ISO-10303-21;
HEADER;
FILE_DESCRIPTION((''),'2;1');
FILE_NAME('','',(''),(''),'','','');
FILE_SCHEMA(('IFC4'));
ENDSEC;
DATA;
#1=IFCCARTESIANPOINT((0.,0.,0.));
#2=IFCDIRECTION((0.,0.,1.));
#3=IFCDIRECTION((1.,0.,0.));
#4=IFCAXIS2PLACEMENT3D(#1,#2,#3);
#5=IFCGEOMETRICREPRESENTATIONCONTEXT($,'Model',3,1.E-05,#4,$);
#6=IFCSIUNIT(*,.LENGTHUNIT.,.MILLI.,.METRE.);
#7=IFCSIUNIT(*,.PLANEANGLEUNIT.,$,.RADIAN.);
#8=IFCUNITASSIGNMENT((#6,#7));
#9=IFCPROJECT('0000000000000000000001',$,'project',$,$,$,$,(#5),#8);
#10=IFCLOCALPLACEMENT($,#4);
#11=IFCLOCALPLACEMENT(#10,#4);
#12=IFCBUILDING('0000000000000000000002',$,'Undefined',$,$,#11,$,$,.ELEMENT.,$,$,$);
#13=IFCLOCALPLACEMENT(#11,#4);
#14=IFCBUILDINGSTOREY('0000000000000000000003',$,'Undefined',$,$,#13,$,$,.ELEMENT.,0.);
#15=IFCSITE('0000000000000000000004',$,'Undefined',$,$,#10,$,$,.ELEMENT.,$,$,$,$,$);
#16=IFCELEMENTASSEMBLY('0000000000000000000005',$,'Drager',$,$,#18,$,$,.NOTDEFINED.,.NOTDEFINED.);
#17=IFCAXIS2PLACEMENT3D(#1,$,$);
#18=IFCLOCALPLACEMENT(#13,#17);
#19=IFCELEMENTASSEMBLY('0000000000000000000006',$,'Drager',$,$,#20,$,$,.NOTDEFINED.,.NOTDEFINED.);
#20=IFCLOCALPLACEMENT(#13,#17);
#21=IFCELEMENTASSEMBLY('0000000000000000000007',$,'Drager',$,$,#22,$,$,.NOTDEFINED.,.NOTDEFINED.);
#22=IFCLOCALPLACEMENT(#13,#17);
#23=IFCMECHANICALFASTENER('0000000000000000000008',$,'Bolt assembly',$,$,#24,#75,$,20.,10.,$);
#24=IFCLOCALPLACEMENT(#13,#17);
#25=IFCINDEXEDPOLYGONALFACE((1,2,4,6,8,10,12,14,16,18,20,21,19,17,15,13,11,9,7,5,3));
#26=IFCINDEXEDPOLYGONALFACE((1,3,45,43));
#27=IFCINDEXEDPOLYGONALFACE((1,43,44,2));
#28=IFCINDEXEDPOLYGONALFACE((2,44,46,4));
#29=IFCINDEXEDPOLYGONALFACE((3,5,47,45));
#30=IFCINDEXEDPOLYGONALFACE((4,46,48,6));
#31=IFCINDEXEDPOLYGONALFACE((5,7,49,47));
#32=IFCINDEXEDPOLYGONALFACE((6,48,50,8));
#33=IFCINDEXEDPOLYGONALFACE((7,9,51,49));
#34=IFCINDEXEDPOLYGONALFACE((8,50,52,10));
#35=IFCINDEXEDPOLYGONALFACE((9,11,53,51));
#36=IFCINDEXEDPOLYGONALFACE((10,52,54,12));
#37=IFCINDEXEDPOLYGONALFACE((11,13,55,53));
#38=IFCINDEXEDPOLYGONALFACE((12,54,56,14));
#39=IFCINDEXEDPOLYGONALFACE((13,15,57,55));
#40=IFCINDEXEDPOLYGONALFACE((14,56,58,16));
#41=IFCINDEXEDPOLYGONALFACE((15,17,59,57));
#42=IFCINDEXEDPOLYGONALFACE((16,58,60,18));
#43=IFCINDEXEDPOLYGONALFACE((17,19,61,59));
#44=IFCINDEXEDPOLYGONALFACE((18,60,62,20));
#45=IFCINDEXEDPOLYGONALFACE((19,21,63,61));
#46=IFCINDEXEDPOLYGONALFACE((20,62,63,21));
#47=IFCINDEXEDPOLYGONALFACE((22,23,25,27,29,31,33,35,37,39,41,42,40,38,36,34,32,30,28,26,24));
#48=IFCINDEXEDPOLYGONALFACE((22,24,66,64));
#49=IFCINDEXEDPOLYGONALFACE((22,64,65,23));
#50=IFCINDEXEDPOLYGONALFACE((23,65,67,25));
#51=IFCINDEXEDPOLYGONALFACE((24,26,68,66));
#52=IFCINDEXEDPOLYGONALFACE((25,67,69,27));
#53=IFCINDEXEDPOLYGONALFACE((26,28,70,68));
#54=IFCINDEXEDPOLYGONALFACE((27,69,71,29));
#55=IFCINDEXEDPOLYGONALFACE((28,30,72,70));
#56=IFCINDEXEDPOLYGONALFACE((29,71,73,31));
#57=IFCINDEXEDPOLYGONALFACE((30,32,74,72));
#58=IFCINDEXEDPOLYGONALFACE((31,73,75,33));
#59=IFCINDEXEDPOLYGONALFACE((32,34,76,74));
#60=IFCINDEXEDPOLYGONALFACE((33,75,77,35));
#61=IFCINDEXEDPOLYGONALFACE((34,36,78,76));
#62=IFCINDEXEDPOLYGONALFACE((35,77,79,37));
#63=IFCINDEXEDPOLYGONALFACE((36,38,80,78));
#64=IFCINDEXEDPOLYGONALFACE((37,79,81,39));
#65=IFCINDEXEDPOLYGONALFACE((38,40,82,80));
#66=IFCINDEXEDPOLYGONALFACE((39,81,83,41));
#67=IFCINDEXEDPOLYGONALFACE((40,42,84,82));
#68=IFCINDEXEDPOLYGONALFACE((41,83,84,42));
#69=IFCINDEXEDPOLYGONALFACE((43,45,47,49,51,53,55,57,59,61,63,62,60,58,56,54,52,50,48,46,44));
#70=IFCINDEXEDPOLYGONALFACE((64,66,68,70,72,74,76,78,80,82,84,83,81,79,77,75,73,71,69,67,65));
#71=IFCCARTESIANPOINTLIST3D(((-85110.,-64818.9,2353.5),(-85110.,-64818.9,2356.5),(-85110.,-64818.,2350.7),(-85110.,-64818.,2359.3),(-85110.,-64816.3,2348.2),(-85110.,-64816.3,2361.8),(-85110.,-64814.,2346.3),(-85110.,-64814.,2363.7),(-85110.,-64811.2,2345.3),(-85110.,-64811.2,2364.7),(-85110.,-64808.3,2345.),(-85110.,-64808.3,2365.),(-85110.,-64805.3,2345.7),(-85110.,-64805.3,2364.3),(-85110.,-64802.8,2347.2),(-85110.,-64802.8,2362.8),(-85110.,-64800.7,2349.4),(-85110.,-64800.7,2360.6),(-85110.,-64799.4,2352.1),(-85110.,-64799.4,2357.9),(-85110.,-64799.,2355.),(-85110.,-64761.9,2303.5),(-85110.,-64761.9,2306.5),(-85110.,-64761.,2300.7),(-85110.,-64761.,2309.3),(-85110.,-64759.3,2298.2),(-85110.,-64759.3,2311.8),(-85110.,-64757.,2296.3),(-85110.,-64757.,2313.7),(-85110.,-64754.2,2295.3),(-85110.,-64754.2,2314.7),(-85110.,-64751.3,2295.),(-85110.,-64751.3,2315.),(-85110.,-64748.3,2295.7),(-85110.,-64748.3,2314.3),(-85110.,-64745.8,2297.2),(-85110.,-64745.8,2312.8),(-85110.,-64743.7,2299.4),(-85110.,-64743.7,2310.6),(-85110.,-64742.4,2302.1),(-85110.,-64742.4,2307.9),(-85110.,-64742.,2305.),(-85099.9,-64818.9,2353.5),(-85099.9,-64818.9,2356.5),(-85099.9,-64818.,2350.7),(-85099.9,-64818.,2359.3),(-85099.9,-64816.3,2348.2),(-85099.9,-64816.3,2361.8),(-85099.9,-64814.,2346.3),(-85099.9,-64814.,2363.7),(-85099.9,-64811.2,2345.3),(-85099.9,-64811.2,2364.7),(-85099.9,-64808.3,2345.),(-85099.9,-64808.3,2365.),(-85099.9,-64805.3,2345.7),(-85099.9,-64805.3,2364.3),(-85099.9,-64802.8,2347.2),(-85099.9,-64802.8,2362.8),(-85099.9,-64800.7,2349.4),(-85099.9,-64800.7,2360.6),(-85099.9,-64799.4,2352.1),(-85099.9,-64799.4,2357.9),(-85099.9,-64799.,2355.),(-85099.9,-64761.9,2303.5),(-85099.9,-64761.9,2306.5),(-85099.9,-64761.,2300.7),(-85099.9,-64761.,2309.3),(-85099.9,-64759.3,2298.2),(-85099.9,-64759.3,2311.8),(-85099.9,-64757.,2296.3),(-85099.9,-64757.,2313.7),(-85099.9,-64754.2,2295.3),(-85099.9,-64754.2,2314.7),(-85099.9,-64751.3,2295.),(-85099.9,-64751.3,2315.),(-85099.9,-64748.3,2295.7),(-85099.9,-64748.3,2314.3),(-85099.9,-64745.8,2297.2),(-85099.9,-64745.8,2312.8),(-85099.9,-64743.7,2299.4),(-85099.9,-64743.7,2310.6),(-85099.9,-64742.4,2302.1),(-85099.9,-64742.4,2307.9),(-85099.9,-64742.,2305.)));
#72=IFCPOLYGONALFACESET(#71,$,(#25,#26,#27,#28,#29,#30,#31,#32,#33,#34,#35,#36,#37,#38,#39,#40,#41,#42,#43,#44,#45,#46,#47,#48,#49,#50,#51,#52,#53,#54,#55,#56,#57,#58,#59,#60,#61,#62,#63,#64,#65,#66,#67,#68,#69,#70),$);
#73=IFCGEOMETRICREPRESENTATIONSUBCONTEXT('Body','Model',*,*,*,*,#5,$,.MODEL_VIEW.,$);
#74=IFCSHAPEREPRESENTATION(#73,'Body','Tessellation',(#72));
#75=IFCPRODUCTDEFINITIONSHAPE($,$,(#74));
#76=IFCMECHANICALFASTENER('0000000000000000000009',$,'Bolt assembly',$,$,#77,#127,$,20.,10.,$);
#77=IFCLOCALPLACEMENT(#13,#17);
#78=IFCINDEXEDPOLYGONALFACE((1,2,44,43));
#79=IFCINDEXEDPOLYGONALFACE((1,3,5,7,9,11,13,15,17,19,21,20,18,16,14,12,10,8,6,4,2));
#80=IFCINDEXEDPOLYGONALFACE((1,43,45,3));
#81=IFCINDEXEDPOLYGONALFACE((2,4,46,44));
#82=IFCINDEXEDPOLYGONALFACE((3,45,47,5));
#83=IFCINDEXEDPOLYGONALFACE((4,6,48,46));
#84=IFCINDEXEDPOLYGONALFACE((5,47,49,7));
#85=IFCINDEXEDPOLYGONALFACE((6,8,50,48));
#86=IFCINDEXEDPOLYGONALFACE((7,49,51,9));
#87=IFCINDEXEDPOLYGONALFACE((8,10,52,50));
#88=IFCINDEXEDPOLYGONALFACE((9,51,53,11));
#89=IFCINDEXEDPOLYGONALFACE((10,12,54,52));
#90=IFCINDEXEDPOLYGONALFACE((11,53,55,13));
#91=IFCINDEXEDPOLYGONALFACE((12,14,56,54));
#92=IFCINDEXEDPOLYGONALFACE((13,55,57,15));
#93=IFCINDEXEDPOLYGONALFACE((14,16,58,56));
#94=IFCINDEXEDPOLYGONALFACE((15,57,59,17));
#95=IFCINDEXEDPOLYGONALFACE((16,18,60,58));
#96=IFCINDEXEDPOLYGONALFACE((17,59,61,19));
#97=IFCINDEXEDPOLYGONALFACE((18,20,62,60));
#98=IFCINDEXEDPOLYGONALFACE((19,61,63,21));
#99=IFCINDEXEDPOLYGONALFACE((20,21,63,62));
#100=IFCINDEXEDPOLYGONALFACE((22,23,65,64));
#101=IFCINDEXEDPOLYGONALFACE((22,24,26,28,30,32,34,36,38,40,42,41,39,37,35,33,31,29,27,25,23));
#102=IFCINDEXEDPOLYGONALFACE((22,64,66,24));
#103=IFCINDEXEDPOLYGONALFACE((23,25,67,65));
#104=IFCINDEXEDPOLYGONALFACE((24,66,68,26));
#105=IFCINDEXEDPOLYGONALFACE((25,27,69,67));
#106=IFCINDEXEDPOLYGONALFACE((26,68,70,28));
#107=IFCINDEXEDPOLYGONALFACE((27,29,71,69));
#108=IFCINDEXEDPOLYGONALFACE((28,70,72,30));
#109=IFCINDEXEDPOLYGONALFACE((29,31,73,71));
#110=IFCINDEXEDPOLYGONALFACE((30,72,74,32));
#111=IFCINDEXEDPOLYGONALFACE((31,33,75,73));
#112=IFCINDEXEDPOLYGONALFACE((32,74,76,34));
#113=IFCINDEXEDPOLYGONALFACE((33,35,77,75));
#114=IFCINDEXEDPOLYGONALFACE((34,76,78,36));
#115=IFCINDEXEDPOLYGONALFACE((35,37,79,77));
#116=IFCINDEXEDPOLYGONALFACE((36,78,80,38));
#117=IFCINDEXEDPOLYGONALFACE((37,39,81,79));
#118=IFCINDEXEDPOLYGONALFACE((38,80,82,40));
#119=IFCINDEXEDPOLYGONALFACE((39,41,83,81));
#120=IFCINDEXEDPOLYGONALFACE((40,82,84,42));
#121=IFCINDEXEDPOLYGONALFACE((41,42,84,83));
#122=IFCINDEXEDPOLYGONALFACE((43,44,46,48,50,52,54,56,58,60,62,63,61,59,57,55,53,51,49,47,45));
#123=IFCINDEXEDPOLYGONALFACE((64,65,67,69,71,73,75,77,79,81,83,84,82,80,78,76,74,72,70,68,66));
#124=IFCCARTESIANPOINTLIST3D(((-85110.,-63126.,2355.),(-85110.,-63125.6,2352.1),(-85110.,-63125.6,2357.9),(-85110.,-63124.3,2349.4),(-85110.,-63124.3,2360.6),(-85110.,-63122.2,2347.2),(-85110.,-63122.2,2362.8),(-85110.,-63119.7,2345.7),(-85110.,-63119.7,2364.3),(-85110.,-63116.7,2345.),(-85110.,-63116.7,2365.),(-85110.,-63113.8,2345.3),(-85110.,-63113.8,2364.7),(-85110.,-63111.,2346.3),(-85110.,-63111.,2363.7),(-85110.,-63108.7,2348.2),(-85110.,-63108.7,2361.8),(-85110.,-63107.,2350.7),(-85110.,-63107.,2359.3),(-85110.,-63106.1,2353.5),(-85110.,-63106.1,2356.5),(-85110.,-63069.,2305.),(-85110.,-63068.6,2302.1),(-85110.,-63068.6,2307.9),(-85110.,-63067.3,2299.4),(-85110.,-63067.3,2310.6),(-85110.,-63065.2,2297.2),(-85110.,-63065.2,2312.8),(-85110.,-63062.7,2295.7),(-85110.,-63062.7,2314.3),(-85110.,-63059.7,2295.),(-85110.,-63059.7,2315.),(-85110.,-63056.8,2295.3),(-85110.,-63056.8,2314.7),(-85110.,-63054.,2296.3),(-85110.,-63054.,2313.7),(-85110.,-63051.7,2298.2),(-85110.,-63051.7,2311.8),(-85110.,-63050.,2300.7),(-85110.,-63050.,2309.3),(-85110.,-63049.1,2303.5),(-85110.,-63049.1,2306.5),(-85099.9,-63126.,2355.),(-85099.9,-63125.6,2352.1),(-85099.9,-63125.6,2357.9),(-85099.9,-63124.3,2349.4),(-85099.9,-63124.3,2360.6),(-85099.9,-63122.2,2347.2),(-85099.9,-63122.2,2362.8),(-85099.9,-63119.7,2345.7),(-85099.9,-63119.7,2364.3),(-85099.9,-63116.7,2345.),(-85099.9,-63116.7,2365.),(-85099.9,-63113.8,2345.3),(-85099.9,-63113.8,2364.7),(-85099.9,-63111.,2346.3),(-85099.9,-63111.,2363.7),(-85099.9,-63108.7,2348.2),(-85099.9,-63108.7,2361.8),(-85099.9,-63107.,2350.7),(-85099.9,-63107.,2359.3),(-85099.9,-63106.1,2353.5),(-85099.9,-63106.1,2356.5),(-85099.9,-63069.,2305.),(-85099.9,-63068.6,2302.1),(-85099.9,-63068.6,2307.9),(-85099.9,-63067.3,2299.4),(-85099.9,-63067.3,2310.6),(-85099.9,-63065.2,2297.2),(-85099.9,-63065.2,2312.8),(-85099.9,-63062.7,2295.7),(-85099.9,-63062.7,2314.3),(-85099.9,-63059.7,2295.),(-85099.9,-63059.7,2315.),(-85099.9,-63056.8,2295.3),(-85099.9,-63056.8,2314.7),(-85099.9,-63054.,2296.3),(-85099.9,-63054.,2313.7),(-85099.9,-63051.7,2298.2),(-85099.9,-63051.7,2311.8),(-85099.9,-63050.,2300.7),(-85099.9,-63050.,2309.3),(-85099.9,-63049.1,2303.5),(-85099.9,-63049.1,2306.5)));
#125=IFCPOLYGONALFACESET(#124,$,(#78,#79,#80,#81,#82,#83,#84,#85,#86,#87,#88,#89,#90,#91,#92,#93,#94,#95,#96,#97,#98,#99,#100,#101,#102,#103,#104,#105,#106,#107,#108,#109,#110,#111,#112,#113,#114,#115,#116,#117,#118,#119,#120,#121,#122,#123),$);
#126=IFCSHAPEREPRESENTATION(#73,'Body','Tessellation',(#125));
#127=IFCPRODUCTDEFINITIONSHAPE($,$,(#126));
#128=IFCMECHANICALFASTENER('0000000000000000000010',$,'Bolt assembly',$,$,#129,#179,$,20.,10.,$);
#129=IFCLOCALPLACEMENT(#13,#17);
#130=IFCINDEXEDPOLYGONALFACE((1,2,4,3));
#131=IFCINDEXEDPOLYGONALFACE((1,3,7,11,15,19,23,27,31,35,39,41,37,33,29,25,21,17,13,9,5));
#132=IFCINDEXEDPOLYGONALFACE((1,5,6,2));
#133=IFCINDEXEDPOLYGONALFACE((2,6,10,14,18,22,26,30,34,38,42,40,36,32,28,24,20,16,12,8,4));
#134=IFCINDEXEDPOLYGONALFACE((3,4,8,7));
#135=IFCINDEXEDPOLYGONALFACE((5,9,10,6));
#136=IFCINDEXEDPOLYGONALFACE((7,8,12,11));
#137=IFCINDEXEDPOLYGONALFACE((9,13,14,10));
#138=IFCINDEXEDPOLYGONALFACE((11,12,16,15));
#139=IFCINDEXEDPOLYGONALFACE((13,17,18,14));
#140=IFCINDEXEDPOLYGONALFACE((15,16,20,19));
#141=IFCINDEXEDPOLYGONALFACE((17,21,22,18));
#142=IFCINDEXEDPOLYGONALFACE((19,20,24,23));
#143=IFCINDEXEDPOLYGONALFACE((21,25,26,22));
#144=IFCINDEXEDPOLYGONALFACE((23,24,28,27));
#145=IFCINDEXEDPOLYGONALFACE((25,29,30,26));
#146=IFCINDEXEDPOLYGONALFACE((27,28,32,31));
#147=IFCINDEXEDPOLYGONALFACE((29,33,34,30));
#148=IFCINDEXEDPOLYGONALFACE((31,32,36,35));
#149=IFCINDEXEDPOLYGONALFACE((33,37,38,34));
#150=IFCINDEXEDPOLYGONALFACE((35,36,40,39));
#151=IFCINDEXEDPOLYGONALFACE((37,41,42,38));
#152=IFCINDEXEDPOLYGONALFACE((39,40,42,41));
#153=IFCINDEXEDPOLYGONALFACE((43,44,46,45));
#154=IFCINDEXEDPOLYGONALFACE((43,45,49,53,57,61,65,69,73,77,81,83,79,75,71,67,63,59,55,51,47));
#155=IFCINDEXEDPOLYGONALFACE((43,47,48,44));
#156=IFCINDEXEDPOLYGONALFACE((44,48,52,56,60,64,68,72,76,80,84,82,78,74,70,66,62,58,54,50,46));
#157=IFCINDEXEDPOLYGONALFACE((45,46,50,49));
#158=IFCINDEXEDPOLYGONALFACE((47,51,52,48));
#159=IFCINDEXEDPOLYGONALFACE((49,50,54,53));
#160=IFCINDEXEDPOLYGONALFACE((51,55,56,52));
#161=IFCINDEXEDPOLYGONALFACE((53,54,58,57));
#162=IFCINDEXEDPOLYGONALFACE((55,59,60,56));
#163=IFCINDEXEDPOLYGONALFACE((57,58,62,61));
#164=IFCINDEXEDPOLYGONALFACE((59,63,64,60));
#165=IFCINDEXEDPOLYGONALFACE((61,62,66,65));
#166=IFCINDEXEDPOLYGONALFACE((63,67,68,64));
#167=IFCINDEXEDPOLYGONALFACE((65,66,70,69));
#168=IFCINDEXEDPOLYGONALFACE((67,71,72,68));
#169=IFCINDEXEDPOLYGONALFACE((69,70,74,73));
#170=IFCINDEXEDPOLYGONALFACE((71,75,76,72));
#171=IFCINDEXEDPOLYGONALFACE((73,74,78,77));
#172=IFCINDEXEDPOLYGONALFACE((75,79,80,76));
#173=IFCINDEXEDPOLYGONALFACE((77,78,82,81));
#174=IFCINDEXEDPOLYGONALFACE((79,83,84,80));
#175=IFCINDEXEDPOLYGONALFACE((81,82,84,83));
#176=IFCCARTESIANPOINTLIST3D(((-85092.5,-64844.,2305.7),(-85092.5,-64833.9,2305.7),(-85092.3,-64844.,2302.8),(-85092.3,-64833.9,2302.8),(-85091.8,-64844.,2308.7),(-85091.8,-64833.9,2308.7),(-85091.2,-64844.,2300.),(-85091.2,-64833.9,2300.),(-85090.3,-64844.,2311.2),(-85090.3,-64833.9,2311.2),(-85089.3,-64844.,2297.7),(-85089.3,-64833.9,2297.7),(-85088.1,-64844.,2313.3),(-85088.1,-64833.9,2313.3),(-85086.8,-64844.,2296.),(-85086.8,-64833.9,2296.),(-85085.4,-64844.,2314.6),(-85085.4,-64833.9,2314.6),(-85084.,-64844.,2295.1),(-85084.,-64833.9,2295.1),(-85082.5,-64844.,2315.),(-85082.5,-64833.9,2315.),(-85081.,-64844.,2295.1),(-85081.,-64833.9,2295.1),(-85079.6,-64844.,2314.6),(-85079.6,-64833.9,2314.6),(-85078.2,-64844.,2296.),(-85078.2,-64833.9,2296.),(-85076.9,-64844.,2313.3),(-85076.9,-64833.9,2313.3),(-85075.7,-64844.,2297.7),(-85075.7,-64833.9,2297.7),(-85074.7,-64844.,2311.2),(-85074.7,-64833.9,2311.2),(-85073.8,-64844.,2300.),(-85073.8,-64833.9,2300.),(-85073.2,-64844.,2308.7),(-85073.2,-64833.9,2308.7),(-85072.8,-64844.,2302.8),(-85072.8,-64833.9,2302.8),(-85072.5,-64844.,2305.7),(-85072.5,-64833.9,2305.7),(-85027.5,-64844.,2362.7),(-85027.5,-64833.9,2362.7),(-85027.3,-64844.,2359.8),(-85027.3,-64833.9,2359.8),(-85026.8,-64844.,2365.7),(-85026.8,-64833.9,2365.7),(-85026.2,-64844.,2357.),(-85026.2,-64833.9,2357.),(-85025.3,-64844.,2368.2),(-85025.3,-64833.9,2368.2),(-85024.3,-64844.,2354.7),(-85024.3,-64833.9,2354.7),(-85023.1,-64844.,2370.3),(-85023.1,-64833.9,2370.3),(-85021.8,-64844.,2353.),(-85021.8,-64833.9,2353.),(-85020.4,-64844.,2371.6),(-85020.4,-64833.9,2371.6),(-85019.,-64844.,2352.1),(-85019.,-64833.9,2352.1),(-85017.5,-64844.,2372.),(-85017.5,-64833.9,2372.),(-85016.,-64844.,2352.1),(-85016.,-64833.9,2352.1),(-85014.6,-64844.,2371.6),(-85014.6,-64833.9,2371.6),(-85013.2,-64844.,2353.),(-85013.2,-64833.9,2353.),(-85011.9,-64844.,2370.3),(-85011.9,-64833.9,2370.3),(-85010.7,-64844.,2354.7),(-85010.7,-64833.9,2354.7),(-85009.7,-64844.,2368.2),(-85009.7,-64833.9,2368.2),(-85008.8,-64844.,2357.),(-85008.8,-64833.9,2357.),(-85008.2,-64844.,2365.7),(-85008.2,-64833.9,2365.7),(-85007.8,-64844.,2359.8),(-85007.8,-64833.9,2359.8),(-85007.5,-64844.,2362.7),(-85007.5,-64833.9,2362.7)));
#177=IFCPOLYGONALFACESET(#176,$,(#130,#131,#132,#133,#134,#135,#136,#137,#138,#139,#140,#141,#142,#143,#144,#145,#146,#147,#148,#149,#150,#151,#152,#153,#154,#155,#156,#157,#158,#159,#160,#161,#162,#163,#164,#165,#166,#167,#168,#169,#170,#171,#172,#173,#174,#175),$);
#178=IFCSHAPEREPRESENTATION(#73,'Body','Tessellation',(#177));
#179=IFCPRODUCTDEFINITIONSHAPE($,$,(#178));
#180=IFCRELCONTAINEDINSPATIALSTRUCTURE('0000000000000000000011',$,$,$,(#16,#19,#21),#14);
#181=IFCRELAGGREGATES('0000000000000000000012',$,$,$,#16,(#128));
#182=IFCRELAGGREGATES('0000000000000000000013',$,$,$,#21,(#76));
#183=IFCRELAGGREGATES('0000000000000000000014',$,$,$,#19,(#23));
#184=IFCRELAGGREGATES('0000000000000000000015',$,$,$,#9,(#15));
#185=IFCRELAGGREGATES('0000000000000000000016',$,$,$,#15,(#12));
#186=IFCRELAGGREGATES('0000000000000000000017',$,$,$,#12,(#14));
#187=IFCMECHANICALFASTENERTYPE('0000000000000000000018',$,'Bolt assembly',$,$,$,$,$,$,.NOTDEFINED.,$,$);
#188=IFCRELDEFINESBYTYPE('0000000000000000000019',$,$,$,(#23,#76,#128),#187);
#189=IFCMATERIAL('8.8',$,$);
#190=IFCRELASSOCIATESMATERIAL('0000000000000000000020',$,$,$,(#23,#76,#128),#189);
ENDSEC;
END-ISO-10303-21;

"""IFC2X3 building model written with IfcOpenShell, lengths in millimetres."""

from ifc_helpers import new_model, si_unit, frame, origin_with_axes, origin_2d_with_axis, place, context, subcontext, project, spatial, circle, extrude, source, transform, mapped, material, type_object, element, aggregate, save


model = new_model("IFC2X3")

# Units and contexts
model_context = context("Model", 3, precision=1e-05, world=origin_with_axes())
body_context = subcontext(model_context, "Body", "Model", "MODEL_VIEW")
ifc_project = project(units=[si_unit("LENGTHUNIT", "METRE", prefix="MILLI"), si_unit("PLANEANGLEUNIT", "RADIAN")], contexts=[model_context])

# Site, building, storey
site_placement = place(None, origin_with_axes())
site = spatial("IfcSite", under=ifc_project, at=site_placement, Name="Undefined", CompositionType="ELEMENT")
building_placement = place(site_placement, origin_with_axes())
building = spatial("IfcBuilding", under=site, at=building_placement, Name="Undefined", CompositionType="ELEMENT")
storey_placement = place(building_placement, origin_with_axes())
storey = spatial("IfcBuildingStorey", under=building, at=storey_placement, Name="Undefined", CompositionType="ELEMENT", Elevation=0.0)

# Element assemblies
assembly_1_placement = place(storey_placement, origin_with_axes())
assembly_1 = element("IfcElementAssembly", 1, at=assembly_1_placement, inside=storey, Name="Drager", AssemblyPlace="NOTDEFINED", PredefinedType="NOTDEFINED")
assembly_2_placement = place(storey_placement, origin_with_axes())
assembly_2 = element("IfcElementAssembly", 2, at=assembly_2_placement, inside=storey, Name="Drager", AssemblyPlace="NOTDEFINED", PredefinedType="NOTDEFINED")
assembly_3_placement = place(storey_placement, origin_with_axes())
assembly_3 = element("IfcElementAssembly", 3, at=assembly_3_placement, inside=storey, Name="Drager", AssemblyPlace="NOTDEFINED", PredefinedType="NOTDEFINED")

# Mechanical fasteners
ifc_material_1 = material(Name="8.8")
mechanical_fastener_type = type_object("IfcMechanicalFastenerType", Name="Bolt assembly")
shared_shape_1 = source(origin_with_axes(), body_context, "Body", "SweptSolid", [
    extrude(circle(Radius=10.0, at=origin_2d_with_axis()), frame((0.0, 0.0, 0.0), z_axis=(0.0, 1.0, 0.0), x_axis=(1.0, 0.0, 0.0)), (0.0, 0.0, 1.0), 10.1),
])
mechanical_fastener_1_placement = place(assembly_2_placement, frame((-85110.0, -64809.0, 2330.0), z_axis=(0.0, 0.0, -1.0), x_axis=(0.0, 1.0, 0.0)))
mechanical_fastener_1 = element("IfcMechanicalFastener", 4, at=mechanical_fastener_1_placement, type_object=mechanical_fastener_type, material=ifc_material_1, Name="Bolt assembly", NominalDiameter=20.0, NominalLength=10.0, context=body_context, shape_type="MappedRepresentation", body=[
    mapped(shared_shape_1, transform((0.0, 0.0, -25.0))),
    mapped(shared_shape_1, transform((57.0, 0.0, 25.0))),
])
mechanical_fastener_2_placement = place(assembly_3_placement, frame((-85110.0, -63059.0, 2330.0), z_axis=(0.0, 0.0, 1.0), x_axis=(0.0, -1.0, 0.0)))
mechanical_fastener_2 = element("IfcMechanicalFastener", 5, at=mechanical_fastener_2_placement, type_object=mechanical_fastener_type, material=ifc_material_1, Name="Bolt assembly", NominalDiameter=20.0, NominalLength=10.0, context=body_context, shape_type="MappedRepresentation", body=[
    mapped(shared_shape_1, transform((0.0, 0.0, -25.0))),
    mapped(shared_shape_1, transform((57.0, 0.0, 25.0))),
])
mechanical_fastener_3_placement = place(assembly_1_placement, frame((-85050.0, -64844.0, 2305.0), z_axis=(-1.0, 0.0, 0.0), x_axis=(0.0, 0.0, 1.0)))
mechanical_fastener_3 = element("IfcMechanicalFastener", 6, at=mechanical_fastener_3_placement, type_object=mechanical_fastener_type, material=ifc_material_1, Name="Bolt assembly", NominalDiameter=20.0, NominalLength=10.0, context=body_context, shape_type="MappedRepresentation", body=[
    mapped(shared_shape_1, transform((57.0, 0.0, -32.5))),
    mapped(shared_shape_1, transform((0.0, 0.0, 32.5))),
])
aggregate(assembly_1, [mechanical_fastener_3])

aggregate(assembly_3, [mechanical_fastener_2])
aggregate(assembly_2, [mechanical_fastener_1])

save(model, "model.ifc")
